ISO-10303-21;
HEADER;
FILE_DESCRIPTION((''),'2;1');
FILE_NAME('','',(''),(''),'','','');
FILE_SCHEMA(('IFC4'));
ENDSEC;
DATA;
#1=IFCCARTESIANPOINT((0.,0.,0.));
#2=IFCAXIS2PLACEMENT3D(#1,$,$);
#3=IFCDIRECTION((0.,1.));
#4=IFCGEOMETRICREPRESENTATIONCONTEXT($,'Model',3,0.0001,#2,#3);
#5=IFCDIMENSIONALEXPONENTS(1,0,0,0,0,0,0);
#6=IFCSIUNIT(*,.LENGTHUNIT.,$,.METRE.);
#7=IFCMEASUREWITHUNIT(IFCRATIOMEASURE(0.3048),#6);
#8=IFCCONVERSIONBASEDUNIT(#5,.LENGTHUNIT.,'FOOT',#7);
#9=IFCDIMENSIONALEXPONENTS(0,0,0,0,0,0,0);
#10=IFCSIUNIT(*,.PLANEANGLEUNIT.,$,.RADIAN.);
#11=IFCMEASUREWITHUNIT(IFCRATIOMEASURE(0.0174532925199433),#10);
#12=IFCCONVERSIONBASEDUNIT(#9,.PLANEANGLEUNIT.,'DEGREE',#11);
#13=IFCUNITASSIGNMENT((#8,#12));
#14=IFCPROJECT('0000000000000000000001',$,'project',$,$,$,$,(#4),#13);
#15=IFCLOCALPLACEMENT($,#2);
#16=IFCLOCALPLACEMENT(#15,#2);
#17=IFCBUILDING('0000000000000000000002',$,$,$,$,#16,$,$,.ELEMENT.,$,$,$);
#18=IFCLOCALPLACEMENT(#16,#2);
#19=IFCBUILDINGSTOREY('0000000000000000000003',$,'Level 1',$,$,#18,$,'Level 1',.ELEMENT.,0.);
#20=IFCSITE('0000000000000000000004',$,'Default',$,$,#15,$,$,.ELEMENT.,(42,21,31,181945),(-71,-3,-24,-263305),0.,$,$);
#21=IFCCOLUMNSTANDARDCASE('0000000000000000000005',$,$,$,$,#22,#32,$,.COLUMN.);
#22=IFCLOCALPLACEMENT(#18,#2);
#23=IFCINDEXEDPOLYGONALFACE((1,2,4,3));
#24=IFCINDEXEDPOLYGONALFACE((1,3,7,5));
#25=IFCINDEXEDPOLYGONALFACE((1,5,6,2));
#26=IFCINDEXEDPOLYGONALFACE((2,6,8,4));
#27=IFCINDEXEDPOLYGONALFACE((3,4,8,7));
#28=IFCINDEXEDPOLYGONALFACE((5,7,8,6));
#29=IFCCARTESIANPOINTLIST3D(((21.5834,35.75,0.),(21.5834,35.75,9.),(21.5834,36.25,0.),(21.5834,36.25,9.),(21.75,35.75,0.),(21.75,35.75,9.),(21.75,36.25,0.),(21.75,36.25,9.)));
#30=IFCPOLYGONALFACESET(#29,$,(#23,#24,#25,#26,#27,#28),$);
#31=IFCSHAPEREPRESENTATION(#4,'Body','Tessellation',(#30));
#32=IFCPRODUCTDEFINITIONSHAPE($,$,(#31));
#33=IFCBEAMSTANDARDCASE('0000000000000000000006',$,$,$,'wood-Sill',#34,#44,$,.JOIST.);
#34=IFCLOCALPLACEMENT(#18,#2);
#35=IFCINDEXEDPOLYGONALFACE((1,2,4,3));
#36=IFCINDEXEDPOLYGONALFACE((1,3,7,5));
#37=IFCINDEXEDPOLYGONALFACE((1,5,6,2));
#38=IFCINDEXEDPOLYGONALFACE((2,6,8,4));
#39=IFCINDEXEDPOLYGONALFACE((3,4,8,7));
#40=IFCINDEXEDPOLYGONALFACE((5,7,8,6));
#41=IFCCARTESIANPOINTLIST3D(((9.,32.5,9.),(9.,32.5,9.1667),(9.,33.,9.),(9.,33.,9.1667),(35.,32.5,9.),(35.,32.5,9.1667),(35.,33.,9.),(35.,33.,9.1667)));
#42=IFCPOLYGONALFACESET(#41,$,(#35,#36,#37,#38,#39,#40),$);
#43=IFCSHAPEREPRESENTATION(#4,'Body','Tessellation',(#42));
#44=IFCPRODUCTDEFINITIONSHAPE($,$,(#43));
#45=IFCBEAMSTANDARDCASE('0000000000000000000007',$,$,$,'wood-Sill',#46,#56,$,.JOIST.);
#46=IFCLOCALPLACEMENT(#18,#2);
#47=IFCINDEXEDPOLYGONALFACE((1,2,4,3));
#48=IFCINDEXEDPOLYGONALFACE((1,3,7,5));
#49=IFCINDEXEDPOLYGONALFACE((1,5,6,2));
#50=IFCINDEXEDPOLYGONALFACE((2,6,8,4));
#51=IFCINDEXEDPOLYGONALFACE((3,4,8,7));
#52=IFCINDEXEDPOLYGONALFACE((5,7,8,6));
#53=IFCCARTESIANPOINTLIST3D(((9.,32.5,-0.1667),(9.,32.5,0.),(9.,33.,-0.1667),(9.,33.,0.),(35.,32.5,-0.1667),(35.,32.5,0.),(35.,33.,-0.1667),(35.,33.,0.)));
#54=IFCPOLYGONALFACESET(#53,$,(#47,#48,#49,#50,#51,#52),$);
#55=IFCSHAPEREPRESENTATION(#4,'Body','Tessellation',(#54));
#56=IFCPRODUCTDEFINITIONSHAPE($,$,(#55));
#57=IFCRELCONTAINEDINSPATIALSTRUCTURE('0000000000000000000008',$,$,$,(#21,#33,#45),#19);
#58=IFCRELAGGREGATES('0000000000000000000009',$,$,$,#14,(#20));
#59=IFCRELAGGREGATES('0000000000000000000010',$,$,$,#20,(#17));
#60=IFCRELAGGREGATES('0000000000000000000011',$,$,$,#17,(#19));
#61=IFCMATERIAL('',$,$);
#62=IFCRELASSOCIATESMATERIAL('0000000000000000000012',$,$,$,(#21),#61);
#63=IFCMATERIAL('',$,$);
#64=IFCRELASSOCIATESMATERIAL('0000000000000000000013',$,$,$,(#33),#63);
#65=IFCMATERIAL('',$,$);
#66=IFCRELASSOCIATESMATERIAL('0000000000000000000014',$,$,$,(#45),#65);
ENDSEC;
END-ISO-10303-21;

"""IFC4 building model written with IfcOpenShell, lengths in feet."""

from ifc_helpers import new_model, entity, si_unit, converted_unit, direction, frame, origin, place, context, project, spatial, rectangle, extrude, material, element, save


model = new_model("IFC4")

# Units and contexts
model_context = context("Model", 3, precision=0.0001, world=origin(), true_north=direction((0.0, 1.0)))
ifc_project = project(units=[converted_unit("LENGTHUNIT", "FOOT", entity("IfcRatioMeasure", 0.3048), si_unit("LENGTHUNIT", "METRE"), dimensions=[1, 0, 0, 0, 0, 0, 0]), converted_unit("PLANEANGLEUNIT", "DEGREE", entity("IfcRatioMeasure", 0.0174532925199433), si_unit("PLANEANGLEUNIT", "RADIAN"), dimensions=[0, 0, 0, 0, 0, 0, 0])], contexts=[model_context])

# Site, building, storey
site_placement = place(None, origin())
site = spatial("IfcSite", under=ifc_project, at=site_placement, Name="Default", CompositionType="ELEMENT", RefLatitude=(42, 21, 31, 181945), RefLongitude=(-71, -3, -24, -263305), RefElevation=0.0)
building_placement = place(site_placement, origin())
building = spatial("IfcBuilding", under=site, at=building_placement, CompositionType="ELEMENT")
storey_placement = place(building_placement, origin())
storey = spatial("IfcBuildingStorey", under=building, at=storey_placement, Name="Level 1", LongName="Level 1", CompositionType="ELEMENT", Elevation=0.0)

# Column
ifc_material_1 = material(Name="")
placement_1 = place(storey_placement, frame((0.25, 36.0, 0.0)))
column_placement = place(placement_1, frame((21.4167, 0.0, 0.0), z_axis=(0.0, 0.0, 1.0), x_axis=(1.0, 0.0, 0.0)))
element("IfcColumnStandardCase", 1, at=column_placement, inside=storey, material=ifc_material_1, PredefinedType="COLUMN", context=model_context, shape_type="SweptSolid", body=[
    extrude(rectangle(XDim=0.1667, YDim=0.5), origin(), (0.0, 0.0, 1.0), 9.0),
])
placement_2 = place(storey_placement, frame((22.0, 45.75, 0.0), z_axis=(0.0, 0.0, 1.0), x_axis=(0.0, -1.0, 0.0)))

# Beams
ifc_material_2 = material(Name="")
beam_1_placement = place(placement_2, frame((13.0, 0.0, 9.0), z_axis=(0.0, 0.0, 1.0), x_axis=(0.0, -1.0, 0.0)))
element("IfcBeamStandardCase", 2, at=beam_1_placement, inside=storey, material=ifc_material_2, ObjectType="wood-Sill", PredefinedType="JOIST", context=model_context, shape_type="SweptSolid", body=[
    extrude(rectangle(XDim=26.0, YDim=0.5), origin(), (0.0, 0.0, 1.0), 0.1667),
])
ifc_material_3 = material(Name="")
beam_2_placement = place(placement_2, frame((13.0, 0.0, -0.1667), z_axis=(0.0, 0.0, 1.0), x_axis=(0.0, -1.0, 0.0)))
element("IfcBeamStandardCase", 3, at=beam_2_placement, inside=storey, material=ifc_material_3, ObjectType="wood-Sill", PredefinedType="JOIST", context=model_context, shape_type="SweptSolid", body=[
    extrude(rectangle(XDim=26.0, YDim=0.5), origin(), (0.0, 0.0, 1.0), 0.1667),
])

save(model, "model.ifc")
